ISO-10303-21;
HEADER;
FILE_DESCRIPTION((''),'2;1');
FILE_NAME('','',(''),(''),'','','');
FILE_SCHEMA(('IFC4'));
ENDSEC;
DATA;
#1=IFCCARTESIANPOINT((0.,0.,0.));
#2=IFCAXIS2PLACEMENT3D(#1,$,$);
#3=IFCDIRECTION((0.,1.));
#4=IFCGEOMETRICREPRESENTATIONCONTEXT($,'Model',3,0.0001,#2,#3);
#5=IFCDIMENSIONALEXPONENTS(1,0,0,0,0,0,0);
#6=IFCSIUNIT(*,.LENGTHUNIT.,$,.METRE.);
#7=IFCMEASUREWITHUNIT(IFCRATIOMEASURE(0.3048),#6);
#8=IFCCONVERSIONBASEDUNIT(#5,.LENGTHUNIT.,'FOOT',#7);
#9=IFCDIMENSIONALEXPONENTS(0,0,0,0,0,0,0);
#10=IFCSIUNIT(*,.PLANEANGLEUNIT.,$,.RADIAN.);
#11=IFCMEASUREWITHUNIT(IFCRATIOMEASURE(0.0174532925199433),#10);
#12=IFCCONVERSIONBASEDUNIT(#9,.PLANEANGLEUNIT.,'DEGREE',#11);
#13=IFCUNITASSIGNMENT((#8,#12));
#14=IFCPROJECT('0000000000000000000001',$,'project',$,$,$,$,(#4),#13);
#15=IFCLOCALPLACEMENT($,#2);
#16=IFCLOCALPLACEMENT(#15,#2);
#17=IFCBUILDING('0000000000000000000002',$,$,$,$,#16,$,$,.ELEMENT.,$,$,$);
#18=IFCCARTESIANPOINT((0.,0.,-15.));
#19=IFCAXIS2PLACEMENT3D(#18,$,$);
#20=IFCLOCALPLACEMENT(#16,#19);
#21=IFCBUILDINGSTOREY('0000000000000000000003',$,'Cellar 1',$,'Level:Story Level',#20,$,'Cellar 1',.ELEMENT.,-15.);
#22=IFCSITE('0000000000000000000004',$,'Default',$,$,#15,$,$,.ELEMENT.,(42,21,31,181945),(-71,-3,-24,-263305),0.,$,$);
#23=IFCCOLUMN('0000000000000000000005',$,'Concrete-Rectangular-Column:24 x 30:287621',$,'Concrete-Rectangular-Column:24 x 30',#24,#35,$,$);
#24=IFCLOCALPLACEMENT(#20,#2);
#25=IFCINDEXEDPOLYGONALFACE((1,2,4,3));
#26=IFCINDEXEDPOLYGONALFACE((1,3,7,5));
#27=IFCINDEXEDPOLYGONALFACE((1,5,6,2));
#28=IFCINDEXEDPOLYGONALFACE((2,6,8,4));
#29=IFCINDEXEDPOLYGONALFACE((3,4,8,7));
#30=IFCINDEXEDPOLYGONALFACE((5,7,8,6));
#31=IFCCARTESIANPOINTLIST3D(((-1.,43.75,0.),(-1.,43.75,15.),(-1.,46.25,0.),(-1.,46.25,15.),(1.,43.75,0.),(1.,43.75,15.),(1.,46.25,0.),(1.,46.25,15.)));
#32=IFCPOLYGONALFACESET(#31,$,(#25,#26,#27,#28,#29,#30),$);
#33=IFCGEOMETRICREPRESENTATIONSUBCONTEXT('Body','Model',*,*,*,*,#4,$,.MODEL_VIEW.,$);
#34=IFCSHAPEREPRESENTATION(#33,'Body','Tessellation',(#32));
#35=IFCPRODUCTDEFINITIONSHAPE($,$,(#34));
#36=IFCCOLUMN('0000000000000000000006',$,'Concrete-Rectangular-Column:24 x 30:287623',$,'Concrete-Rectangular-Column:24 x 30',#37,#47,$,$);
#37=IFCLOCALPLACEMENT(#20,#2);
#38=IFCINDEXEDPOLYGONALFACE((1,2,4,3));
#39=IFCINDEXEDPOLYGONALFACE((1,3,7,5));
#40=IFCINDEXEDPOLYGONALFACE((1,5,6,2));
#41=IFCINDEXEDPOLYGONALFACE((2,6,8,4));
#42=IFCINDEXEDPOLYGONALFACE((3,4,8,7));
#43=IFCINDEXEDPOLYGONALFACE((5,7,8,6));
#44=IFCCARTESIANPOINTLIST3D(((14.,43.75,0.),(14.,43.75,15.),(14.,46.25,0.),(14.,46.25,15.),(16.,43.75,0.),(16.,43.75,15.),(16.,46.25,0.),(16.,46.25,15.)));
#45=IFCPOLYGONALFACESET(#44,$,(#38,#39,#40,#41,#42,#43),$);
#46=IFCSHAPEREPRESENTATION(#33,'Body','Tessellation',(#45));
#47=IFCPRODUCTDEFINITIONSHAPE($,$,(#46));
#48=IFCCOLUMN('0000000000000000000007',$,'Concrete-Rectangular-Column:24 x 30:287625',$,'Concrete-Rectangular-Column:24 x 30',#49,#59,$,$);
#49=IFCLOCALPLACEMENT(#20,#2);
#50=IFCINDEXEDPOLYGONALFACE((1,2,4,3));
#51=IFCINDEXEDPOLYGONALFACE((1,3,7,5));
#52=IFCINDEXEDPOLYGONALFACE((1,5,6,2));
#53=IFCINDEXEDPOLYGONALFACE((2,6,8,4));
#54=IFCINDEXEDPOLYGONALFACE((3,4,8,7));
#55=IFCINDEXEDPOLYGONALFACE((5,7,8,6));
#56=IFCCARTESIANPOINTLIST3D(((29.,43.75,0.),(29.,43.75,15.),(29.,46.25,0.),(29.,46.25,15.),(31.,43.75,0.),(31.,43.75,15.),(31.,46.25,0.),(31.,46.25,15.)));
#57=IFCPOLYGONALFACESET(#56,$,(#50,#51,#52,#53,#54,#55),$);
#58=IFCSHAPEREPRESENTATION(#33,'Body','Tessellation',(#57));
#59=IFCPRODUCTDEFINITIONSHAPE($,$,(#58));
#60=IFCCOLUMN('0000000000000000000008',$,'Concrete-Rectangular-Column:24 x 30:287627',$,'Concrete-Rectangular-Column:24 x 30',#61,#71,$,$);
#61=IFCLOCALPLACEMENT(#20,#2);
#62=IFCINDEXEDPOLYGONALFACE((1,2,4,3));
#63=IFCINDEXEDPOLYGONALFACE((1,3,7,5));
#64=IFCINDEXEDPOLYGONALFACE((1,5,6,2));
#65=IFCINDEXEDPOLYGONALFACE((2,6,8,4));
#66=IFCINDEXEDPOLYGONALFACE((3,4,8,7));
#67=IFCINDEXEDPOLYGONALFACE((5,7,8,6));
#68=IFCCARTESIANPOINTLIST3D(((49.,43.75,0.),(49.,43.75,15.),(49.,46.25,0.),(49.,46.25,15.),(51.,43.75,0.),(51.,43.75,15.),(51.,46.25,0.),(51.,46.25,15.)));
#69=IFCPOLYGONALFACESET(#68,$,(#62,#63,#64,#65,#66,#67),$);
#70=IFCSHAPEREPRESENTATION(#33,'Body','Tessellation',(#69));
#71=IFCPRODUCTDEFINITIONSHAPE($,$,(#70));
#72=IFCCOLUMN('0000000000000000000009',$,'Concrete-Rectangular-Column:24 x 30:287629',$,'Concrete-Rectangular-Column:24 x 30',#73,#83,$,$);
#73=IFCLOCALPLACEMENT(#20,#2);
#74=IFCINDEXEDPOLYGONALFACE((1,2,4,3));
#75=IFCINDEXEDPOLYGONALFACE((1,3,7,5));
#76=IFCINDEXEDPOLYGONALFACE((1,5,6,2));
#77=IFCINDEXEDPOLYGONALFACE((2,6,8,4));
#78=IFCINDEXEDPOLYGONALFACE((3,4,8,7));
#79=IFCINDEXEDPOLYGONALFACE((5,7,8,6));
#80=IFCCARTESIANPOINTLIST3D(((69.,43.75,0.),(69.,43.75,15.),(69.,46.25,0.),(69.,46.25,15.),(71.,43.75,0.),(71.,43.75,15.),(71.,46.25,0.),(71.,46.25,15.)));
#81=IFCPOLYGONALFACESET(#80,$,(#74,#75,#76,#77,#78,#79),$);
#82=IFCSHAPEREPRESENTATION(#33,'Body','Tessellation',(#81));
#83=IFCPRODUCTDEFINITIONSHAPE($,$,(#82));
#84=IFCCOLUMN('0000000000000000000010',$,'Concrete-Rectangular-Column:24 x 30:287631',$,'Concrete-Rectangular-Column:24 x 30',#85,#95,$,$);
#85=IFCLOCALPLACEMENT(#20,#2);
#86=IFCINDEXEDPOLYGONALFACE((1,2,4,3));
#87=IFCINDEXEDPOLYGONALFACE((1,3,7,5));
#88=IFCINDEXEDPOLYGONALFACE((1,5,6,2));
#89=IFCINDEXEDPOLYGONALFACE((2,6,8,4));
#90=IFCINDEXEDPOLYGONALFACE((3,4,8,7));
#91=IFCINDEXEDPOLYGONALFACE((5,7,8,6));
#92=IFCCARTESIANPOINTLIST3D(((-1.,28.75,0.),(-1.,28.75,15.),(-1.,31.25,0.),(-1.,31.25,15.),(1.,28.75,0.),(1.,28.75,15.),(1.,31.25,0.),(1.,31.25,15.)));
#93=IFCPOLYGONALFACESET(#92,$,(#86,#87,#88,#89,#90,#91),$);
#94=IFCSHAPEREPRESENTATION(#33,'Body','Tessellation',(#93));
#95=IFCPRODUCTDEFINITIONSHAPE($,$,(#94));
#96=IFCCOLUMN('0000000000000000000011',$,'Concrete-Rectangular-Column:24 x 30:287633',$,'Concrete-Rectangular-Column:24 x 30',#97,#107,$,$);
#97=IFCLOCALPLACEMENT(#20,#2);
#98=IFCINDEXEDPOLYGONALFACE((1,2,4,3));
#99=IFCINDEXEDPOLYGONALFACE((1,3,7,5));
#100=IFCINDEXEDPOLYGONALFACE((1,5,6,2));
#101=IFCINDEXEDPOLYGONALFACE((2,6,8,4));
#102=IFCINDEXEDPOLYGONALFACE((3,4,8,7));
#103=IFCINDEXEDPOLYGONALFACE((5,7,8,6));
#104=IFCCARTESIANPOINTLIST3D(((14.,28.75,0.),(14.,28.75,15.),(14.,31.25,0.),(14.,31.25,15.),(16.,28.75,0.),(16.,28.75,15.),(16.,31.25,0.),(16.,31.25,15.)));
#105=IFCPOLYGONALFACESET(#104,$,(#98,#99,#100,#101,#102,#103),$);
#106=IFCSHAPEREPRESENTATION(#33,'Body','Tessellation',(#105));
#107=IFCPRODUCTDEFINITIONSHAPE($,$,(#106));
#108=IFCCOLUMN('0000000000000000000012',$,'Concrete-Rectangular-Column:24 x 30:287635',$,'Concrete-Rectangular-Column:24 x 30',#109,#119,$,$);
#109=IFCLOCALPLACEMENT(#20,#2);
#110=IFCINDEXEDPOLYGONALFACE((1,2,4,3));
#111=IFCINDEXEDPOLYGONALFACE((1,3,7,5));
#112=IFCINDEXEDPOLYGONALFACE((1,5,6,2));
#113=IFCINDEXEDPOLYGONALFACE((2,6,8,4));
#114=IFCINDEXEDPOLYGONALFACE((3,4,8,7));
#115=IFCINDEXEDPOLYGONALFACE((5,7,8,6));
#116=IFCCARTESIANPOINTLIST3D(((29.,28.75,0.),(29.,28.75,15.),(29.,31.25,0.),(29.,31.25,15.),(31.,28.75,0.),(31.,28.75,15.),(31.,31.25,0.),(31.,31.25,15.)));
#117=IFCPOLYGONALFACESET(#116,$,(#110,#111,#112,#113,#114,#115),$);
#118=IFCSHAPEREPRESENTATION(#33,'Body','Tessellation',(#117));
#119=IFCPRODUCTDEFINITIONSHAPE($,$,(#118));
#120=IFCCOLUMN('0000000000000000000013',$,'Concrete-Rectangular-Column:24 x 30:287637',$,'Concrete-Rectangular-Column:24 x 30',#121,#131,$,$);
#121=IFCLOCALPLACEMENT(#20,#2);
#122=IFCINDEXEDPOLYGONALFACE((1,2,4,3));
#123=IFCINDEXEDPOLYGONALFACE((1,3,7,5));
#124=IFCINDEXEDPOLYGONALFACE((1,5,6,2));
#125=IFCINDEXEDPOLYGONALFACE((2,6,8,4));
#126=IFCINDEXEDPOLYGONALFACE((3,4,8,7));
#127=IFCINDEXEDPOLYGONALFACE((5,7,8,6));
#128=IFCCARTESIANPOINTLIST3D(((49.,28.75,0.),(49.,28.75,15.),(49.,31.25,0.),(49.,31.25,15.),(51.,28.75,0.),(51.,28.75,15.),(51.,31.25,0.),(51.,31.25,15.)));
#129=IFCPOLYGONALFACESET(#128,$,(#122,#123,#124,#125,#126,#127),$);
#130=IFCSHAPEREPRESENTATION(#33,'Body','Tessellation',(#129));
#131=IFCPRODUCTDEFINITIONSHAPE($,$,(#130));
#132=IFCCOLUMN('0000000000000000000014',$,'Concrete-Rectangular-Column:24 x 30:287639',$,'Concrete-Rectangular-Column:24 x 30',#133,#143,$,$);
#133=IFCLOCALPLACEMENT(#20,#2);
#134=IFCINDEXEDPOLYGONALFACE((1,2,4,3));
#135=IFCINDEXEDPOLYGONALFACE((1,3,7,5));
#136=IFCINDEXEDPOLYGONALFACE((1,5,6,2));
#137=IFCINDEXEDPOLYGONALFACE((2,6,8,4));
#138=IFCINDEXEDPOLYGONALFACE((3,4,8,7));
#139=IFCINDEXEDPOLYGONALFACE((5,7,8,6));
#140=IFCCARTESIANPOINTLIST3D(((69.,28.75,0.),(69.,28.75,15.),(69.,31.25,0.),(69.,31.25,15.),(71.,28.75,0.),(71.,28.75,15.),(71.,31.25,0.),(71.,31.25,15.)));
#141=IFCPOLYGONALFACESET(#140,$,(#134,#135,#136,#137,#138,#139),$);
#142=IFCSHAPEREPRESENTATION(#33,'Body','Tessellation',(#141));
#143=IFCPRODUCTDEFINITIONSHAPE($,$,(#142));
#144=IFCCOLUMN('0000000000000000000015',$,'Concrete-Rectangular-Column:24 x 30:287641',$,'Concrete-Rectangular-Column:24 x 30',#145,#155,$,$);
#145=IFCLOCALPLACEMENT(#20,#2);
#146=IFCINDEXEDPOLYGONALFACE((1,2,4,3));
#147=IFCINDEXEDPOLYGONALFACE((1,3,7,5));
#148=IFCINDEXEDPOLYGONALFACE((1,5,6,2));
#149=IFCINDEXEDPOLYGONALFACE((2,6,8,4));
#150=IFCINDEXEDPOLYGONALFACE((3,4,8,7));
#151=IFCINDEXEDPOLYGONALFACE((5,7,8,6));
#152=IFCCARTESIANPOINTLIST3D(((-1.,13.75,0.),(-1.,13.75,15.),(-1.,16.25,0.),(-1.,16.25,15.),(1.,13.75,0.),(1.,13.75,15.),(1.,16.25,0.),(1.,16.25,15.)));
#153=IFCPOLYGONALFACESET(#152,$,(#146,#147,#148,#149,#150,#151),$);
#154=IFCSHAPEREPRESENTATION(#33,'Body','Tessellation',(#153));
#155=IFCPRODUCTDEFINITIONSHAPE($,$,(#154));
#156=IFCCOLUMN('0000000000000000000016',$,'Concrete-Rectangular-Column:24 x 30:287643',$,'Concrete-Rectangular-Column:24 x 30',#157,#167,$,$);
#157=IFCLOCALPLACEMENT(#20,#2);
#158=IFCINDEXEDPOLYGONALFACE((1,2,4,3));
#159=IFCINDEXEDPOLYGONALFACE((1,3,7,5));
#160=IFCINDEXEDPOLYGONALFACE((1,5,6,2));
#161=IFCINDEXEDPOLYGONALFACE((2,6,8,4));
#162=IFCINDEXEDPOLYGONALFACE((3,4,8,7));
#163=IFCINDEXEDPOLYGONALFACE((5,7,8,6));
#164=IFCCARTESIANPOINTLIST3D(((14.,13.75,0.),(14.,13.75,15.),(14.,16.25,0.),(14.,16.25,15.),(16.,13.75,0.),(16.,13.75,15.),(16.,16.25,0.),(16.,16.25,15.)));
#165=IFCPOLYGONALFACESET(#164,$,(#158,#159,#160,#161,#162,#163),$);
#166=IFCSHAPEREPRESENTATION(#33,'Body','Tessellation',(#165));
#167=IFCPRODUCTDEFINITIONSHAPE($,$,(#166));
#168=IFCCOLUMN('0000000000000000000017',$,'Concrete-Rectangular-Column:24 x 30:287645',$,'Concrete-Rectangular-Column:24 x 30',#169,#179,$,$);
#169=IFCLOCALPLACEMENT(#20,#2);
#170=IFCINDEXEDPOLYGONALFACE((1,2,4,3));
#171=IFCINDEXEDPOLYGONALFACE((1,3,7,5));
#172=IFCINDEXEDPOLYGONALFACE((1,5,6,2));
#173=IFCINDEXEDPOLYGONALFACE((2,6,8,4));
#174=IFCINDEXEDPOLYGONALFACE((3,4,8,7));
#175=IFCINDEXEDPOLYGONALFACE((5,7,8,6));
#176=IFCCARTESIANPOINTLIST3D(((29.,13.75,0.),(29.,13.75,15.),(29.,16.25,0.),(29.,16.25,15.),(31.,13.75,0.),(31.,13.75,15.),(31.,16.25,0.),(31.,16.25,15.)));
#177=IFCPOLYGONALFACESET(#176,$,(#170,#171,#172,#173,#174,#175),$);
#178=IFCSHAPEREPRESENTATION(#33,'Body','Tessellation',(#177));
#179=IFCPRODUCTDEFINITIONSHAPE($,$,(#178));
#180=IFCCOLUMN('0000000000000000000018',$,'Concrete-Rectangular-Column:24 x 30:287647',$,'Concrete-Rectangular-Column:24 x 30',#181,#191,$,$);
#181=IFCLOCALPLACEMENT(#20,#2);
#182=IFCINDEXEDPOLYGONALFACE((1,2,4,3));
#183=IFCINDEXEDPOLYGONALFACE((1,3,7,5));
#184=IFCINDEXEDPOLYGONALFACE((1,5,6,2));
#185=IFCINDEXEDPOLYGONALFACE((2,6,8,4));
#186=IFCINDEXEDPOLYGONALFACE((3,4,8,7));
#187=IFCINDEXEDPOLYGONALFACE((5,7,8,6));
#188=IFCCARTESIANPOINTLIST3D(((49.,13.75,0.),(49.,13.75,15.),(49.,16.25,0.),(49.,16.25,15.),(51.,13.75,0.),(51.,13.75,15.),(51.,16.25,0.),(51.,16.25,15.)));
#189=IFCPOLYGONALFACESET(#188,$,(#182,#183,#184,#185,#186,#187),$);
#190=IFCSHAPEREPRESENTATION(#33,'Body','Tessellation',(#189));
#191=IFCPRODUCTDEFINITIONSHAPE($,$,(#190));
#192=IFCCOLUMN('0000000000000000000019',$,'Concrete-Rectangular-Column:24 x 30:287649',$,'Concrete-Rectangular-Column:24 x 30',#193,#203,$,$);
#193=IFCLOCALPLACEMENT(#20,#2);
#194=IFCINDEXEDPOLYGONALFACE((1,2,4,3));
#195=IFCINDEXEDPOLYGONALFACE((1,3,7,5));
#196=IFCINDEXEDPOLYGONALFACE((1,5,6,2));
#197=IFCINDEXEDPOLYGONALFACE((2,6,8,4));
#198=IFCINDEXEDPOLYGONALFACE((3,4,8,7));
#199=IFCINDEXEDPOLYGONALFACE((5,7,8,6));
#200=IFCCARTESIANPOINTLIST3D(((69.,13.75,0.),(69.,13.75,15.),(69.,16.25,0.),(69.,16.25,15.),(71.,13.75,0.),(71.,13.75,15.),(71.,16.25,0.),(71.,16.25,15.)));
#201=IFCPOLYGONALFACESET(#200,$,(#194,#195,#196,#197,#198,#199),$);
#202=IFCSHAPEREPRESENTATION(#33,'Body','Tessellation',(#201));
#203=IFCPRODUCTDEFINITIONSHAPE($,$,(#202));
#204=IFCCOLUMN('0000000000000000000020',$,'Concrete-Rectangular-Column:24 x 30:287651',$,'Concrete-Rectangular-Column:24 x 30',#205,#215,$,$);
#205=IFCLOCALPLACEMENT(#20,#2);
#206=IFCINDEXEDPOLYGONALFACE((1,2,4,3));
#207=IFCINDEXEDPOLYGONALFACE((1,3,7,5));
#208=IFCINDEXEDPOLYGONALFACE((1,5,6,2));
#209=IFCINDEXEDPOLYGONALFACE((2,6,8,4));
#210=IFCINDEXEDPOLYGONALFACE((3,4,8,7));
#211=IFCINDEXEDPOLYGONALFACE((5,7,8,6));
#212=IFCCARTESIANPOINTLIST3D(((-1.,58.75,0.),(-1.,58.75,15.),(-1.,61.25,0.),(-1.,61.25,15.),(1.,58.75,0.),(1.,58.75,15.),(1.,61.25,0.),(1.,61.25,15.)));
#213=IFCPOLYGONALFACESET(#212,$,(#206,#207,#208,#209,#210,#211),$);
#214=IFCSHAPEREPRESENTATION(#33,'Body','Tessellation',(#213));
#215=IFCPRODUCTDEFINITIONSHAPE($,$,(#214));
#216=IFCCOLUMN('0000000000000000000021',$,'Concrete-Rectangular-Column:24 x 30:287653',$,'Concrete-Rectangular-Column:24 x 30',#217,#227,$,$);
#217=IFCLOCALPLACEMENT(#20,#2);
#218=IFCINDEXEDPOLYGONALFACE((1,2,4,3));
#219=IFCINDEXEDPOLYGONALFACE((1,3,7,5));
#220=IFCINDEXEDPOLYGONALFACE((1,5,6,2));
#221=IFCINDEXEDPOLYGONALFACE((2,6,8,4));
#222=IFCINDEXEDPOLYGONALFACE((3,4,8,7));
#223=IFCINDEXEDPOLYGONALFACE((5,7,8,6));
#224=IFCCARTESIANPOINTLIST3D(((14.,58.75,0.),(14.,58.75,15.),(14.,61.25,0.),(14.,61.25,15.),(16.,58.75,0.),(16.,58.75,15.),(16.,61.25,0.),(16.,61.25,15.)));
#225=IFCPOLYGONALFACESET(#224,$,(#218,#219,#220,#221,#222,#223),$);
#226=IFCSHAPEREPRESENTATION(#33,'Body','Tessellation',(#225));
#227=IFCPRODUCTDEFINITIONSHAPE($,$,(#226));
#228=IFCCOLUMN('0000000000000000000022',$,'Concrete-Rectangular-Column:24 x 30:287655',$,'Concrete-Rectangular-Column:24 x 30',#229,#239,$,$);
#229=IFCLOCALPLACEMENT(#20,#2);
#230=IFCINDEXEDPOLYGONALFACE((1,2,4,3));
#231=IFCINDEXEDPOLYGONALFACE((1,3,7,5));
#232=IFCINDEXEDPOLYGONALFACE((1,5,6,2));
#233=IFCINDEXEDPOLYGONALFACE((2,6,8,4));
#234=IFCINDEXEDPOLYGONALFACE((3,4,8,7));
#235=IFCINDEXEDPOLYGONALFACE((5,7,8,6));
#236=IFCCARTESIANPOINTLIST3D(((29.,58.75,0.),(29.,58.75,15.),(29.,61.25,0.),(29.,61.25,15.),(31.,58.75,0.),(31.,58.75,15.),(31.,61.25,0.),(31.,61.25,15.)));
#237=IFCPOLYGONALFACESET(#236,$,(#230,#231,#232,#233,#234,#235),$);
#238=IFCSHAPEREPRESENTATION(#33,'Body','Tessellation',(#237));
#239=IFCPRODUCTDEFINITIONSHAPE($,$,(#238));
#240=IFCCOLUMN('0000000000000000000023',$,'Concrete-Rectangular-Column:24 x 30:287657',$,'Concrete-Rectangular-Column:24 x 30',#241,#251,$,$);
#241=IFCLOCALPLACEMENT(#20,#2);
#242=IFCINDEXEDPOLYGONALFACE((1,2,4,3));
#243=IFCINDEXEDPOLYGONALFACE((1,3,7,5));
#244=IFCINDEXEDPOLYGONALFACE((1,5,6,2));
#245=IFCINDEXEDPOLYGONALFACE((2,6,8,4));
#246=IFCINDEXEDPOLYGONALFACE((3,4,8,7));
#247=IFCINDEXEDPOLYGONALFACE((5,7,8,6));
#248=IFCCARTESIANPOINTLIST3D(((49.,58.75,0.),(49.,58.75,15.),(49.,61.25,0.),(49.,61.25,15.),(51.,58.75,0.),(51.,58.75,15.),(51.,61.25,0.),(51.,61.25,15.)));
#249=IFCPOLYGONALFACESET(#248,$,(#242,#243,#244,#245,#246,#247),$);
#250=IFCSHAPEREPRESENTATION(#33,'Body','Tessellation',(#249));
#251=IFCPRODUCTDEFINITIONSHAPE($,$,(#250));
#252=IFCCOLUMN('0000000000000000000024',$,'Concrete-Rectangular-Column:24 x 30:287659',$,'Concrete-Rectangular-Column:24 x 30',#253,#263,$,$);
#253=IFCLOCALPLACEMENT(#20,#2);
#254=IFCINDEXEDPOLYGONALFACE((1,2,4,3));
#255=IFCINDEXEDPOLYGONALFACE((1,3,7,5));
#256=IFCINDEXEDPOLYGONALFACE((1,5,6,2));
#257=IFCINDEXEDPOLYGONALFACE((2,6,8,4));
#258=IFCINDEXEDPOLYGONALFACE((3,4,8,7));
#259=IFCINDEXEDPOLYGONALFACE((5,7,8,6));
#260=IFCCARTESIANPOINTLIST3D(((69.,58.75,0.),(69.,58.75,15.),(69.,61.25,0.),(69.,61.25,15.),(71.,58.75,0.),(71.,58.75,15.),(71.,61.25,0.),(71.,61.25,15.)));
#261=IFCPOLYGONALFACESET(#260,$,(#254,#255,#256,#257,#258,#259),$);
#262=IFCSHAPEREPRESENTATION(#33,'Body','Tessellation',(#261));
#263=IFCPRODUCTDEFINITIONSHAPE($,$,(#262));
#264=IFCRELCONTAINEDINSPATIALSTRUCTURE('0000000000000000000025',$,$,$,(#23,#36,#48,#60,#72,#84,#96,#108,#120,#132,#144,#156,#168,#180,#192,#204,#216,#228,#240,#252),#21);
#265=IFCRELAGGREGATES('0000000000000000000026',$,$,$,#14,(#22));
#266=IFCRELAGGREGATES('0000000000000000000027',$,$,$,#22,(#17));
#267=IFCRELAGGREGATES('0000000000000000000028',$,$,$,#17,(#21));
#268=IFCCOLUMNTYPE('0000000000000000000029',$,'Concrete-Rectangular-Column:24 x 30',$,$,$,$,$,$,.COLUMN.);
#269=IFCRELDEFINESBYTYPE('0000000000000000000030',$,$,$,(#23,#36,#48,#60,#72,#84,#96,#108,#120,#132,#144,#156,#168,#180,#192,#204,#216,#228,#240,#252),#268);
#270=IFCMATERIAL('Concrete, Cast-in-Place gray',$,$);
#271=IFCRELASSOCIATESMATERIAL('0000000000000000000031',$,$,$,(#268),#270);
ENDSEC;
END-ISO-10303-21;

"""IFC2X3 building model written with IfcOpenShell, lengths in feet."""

from ifc_helpers import new_model, entity, si_unit, converted_unit, direction, frame, origin, origin_2d_with_axis, place, context, subcontext, project, spatial, rectangle, extrude, source, transform, mapped, material, type_object, type_shapes, element, save


model = new_model("IFC2X3")

# Units and contexts
model_context = context("Model", 3, precision=0.0001, world=origin(), true_north=direction((0.0, 1.0)))
body_context = subcontext(model_context, "Body", "Model", "MODEL_VIEW")
ifc_project = project(units=[converted_unit("LENGTHUNIT", "FOOT", entity("IfcRatioMeasure", 0.3048), si_unit("LENGTHUNIT", "METRE"), dimensions=[1, 0, 0, 0, 0, 0, 0]), converted_unit("PLANEANGLEUNIT", "DEGREE", entity("IfcRatioMeasure", 0.0174532925199433), si_unit("PLANEANGLEUNIT", "RADIAN"), dimensions=[0, 0, 0, 0, 0, 0, 0])], contexts=[model_context])

# Site, building, storey
site_placement = place(None, origin())
site = spatial("IfcSite", under=ifc_project, at=site_placement, Name="Default", CompositionType="ELEMENT", RefLatitude=(42, 21, 31, 181945), RefLongitude=(-71, -3, -24, -263305), RefElevation=0.0)
building_placement = place(site_placement, origin())
building = spatial("IfcBuilding", under=site, at=building_placement, CompositionType="ELEMENT")
storey_placement = place(building_placement, frame((0.0, 0.0, -15.0)))
storey = spatial("IfcBuildingStorey", under=building, at=storey_placement, Name="Cellar 1", ObjectType="Level:Story Level", LongName="Cellar 1", CompositionType="ELEMENT", Elevation=-15.0)

# Columns
ifc_material = material(Name="Concrete, Cast-in-Place gray")
column_type = type_object("IfcColumnType", Name="Concrete-Rectangular-Column:24 x 30", PredefinedType="COLUMN", material=ifc_material)
shared_shape = source(origin(), body_context, "Body", "SweptSolid", [
    extrude(rectangle(XDim=2.5, YDim=2.0, at=origin_2d_with_axis()), frame((0.0, 0.0, -15.0), z_axis=(0.0, 0.0, 1.0), x_axis=(0.0, -1.0, 0.0)), (0.0, 0.0, 1.0), 15.0),
])
type_shapes(column_type, [shared_shape])
for number, where, name in (
    (1, (0.0, 45.0, 15.0), "Concrete-Rectangular-Column:24 x 30:287621"),
    (2, (15.0, 45.0, 15.0), "Concrete-Rectangular-Column:24 x 30:287623"),
    (3, (30.0, 45.0, 15.0), "Concrete-Rectangular-Column:24 x 30:287625"),
    (4, (50.0, 45.0, 15.0), "Concrete-Rectangular-Column:24 x 30:287627"),
    (5, (70.0, 45.0, 15.0), "Concrete-Rectangular-Column:24 x 30:287629"),
    (6, (0.0, 30.0, 15.0), "Concrete-Rectangular-Column:24 x 30:287631"),
    (7, (15.0, 30.0, 15.0), "Concrete-Rectangular-Column:24 x 30:287633"),
    (8, (30.0, 30.0, 15.0), "Concrete-Rectangular-Column:24 x 30:287635"),
    (9, (50.0, 30.0, 15.0), "Concrete-Rectangular-Column:24 x 30:287637"),
    (10, (70.0, 30.0, 15.0), "Concrete-Rectangular-Column:24 x 30:287639"),
    (11, (0.0, 15.0, 15.0), "Concrete-Rectangular-Column:24 x 30:287641"),
    (12, (15.0, 15.0, 15.0), "Concrete-Rectangular-Column:24 x 30:287643"),
    (13, (30.0, 15.0, 15.0), "Concrete-Rectangular-Column:24 x 30:287645"),
    (14, (50.0, 15.0, 15.0), "Concrete-Rectangular-Column:24 x 30:287647"),
    (15, (70.0, 15.0, 15.0), "Concrete-Rectangular-Column:24 x 30:287649"),
    (16, (0.0, 60.0, 15.0), "Concrete-Rectangular-Column:24 x 30:287651"),
    (17, (15.0, 60.0, 15.0), "Concrete-Rectangular-Column:24 x 30:287653"),
    (18, (30.0, 60.0, 15.0), "Concrete-Rectangular-Column:24 x 30:287655"),
    (19, (50.0, 60.0, 15.0), "Concrete-Rectangular-Column:24 x 30:287657"),
    (20, (70.0, 60.0, 15.0), "Concrete-Rectangular-Column:24 x 30:287659"),
):
    element("IfcColumn", number, at=place(storey_placement, frame(where)), inside=storey, type_object=column_type, Name=name, ObjectType="Concrete-Rectangular-Column:24 x 30", context=body_context, shape_type="MappedRepresentation", body=[
        mapped(shared_shape, transform((0.0, 0.0, 0.0), scale=1.0)),
    ])

save(model, "model.ifc")
